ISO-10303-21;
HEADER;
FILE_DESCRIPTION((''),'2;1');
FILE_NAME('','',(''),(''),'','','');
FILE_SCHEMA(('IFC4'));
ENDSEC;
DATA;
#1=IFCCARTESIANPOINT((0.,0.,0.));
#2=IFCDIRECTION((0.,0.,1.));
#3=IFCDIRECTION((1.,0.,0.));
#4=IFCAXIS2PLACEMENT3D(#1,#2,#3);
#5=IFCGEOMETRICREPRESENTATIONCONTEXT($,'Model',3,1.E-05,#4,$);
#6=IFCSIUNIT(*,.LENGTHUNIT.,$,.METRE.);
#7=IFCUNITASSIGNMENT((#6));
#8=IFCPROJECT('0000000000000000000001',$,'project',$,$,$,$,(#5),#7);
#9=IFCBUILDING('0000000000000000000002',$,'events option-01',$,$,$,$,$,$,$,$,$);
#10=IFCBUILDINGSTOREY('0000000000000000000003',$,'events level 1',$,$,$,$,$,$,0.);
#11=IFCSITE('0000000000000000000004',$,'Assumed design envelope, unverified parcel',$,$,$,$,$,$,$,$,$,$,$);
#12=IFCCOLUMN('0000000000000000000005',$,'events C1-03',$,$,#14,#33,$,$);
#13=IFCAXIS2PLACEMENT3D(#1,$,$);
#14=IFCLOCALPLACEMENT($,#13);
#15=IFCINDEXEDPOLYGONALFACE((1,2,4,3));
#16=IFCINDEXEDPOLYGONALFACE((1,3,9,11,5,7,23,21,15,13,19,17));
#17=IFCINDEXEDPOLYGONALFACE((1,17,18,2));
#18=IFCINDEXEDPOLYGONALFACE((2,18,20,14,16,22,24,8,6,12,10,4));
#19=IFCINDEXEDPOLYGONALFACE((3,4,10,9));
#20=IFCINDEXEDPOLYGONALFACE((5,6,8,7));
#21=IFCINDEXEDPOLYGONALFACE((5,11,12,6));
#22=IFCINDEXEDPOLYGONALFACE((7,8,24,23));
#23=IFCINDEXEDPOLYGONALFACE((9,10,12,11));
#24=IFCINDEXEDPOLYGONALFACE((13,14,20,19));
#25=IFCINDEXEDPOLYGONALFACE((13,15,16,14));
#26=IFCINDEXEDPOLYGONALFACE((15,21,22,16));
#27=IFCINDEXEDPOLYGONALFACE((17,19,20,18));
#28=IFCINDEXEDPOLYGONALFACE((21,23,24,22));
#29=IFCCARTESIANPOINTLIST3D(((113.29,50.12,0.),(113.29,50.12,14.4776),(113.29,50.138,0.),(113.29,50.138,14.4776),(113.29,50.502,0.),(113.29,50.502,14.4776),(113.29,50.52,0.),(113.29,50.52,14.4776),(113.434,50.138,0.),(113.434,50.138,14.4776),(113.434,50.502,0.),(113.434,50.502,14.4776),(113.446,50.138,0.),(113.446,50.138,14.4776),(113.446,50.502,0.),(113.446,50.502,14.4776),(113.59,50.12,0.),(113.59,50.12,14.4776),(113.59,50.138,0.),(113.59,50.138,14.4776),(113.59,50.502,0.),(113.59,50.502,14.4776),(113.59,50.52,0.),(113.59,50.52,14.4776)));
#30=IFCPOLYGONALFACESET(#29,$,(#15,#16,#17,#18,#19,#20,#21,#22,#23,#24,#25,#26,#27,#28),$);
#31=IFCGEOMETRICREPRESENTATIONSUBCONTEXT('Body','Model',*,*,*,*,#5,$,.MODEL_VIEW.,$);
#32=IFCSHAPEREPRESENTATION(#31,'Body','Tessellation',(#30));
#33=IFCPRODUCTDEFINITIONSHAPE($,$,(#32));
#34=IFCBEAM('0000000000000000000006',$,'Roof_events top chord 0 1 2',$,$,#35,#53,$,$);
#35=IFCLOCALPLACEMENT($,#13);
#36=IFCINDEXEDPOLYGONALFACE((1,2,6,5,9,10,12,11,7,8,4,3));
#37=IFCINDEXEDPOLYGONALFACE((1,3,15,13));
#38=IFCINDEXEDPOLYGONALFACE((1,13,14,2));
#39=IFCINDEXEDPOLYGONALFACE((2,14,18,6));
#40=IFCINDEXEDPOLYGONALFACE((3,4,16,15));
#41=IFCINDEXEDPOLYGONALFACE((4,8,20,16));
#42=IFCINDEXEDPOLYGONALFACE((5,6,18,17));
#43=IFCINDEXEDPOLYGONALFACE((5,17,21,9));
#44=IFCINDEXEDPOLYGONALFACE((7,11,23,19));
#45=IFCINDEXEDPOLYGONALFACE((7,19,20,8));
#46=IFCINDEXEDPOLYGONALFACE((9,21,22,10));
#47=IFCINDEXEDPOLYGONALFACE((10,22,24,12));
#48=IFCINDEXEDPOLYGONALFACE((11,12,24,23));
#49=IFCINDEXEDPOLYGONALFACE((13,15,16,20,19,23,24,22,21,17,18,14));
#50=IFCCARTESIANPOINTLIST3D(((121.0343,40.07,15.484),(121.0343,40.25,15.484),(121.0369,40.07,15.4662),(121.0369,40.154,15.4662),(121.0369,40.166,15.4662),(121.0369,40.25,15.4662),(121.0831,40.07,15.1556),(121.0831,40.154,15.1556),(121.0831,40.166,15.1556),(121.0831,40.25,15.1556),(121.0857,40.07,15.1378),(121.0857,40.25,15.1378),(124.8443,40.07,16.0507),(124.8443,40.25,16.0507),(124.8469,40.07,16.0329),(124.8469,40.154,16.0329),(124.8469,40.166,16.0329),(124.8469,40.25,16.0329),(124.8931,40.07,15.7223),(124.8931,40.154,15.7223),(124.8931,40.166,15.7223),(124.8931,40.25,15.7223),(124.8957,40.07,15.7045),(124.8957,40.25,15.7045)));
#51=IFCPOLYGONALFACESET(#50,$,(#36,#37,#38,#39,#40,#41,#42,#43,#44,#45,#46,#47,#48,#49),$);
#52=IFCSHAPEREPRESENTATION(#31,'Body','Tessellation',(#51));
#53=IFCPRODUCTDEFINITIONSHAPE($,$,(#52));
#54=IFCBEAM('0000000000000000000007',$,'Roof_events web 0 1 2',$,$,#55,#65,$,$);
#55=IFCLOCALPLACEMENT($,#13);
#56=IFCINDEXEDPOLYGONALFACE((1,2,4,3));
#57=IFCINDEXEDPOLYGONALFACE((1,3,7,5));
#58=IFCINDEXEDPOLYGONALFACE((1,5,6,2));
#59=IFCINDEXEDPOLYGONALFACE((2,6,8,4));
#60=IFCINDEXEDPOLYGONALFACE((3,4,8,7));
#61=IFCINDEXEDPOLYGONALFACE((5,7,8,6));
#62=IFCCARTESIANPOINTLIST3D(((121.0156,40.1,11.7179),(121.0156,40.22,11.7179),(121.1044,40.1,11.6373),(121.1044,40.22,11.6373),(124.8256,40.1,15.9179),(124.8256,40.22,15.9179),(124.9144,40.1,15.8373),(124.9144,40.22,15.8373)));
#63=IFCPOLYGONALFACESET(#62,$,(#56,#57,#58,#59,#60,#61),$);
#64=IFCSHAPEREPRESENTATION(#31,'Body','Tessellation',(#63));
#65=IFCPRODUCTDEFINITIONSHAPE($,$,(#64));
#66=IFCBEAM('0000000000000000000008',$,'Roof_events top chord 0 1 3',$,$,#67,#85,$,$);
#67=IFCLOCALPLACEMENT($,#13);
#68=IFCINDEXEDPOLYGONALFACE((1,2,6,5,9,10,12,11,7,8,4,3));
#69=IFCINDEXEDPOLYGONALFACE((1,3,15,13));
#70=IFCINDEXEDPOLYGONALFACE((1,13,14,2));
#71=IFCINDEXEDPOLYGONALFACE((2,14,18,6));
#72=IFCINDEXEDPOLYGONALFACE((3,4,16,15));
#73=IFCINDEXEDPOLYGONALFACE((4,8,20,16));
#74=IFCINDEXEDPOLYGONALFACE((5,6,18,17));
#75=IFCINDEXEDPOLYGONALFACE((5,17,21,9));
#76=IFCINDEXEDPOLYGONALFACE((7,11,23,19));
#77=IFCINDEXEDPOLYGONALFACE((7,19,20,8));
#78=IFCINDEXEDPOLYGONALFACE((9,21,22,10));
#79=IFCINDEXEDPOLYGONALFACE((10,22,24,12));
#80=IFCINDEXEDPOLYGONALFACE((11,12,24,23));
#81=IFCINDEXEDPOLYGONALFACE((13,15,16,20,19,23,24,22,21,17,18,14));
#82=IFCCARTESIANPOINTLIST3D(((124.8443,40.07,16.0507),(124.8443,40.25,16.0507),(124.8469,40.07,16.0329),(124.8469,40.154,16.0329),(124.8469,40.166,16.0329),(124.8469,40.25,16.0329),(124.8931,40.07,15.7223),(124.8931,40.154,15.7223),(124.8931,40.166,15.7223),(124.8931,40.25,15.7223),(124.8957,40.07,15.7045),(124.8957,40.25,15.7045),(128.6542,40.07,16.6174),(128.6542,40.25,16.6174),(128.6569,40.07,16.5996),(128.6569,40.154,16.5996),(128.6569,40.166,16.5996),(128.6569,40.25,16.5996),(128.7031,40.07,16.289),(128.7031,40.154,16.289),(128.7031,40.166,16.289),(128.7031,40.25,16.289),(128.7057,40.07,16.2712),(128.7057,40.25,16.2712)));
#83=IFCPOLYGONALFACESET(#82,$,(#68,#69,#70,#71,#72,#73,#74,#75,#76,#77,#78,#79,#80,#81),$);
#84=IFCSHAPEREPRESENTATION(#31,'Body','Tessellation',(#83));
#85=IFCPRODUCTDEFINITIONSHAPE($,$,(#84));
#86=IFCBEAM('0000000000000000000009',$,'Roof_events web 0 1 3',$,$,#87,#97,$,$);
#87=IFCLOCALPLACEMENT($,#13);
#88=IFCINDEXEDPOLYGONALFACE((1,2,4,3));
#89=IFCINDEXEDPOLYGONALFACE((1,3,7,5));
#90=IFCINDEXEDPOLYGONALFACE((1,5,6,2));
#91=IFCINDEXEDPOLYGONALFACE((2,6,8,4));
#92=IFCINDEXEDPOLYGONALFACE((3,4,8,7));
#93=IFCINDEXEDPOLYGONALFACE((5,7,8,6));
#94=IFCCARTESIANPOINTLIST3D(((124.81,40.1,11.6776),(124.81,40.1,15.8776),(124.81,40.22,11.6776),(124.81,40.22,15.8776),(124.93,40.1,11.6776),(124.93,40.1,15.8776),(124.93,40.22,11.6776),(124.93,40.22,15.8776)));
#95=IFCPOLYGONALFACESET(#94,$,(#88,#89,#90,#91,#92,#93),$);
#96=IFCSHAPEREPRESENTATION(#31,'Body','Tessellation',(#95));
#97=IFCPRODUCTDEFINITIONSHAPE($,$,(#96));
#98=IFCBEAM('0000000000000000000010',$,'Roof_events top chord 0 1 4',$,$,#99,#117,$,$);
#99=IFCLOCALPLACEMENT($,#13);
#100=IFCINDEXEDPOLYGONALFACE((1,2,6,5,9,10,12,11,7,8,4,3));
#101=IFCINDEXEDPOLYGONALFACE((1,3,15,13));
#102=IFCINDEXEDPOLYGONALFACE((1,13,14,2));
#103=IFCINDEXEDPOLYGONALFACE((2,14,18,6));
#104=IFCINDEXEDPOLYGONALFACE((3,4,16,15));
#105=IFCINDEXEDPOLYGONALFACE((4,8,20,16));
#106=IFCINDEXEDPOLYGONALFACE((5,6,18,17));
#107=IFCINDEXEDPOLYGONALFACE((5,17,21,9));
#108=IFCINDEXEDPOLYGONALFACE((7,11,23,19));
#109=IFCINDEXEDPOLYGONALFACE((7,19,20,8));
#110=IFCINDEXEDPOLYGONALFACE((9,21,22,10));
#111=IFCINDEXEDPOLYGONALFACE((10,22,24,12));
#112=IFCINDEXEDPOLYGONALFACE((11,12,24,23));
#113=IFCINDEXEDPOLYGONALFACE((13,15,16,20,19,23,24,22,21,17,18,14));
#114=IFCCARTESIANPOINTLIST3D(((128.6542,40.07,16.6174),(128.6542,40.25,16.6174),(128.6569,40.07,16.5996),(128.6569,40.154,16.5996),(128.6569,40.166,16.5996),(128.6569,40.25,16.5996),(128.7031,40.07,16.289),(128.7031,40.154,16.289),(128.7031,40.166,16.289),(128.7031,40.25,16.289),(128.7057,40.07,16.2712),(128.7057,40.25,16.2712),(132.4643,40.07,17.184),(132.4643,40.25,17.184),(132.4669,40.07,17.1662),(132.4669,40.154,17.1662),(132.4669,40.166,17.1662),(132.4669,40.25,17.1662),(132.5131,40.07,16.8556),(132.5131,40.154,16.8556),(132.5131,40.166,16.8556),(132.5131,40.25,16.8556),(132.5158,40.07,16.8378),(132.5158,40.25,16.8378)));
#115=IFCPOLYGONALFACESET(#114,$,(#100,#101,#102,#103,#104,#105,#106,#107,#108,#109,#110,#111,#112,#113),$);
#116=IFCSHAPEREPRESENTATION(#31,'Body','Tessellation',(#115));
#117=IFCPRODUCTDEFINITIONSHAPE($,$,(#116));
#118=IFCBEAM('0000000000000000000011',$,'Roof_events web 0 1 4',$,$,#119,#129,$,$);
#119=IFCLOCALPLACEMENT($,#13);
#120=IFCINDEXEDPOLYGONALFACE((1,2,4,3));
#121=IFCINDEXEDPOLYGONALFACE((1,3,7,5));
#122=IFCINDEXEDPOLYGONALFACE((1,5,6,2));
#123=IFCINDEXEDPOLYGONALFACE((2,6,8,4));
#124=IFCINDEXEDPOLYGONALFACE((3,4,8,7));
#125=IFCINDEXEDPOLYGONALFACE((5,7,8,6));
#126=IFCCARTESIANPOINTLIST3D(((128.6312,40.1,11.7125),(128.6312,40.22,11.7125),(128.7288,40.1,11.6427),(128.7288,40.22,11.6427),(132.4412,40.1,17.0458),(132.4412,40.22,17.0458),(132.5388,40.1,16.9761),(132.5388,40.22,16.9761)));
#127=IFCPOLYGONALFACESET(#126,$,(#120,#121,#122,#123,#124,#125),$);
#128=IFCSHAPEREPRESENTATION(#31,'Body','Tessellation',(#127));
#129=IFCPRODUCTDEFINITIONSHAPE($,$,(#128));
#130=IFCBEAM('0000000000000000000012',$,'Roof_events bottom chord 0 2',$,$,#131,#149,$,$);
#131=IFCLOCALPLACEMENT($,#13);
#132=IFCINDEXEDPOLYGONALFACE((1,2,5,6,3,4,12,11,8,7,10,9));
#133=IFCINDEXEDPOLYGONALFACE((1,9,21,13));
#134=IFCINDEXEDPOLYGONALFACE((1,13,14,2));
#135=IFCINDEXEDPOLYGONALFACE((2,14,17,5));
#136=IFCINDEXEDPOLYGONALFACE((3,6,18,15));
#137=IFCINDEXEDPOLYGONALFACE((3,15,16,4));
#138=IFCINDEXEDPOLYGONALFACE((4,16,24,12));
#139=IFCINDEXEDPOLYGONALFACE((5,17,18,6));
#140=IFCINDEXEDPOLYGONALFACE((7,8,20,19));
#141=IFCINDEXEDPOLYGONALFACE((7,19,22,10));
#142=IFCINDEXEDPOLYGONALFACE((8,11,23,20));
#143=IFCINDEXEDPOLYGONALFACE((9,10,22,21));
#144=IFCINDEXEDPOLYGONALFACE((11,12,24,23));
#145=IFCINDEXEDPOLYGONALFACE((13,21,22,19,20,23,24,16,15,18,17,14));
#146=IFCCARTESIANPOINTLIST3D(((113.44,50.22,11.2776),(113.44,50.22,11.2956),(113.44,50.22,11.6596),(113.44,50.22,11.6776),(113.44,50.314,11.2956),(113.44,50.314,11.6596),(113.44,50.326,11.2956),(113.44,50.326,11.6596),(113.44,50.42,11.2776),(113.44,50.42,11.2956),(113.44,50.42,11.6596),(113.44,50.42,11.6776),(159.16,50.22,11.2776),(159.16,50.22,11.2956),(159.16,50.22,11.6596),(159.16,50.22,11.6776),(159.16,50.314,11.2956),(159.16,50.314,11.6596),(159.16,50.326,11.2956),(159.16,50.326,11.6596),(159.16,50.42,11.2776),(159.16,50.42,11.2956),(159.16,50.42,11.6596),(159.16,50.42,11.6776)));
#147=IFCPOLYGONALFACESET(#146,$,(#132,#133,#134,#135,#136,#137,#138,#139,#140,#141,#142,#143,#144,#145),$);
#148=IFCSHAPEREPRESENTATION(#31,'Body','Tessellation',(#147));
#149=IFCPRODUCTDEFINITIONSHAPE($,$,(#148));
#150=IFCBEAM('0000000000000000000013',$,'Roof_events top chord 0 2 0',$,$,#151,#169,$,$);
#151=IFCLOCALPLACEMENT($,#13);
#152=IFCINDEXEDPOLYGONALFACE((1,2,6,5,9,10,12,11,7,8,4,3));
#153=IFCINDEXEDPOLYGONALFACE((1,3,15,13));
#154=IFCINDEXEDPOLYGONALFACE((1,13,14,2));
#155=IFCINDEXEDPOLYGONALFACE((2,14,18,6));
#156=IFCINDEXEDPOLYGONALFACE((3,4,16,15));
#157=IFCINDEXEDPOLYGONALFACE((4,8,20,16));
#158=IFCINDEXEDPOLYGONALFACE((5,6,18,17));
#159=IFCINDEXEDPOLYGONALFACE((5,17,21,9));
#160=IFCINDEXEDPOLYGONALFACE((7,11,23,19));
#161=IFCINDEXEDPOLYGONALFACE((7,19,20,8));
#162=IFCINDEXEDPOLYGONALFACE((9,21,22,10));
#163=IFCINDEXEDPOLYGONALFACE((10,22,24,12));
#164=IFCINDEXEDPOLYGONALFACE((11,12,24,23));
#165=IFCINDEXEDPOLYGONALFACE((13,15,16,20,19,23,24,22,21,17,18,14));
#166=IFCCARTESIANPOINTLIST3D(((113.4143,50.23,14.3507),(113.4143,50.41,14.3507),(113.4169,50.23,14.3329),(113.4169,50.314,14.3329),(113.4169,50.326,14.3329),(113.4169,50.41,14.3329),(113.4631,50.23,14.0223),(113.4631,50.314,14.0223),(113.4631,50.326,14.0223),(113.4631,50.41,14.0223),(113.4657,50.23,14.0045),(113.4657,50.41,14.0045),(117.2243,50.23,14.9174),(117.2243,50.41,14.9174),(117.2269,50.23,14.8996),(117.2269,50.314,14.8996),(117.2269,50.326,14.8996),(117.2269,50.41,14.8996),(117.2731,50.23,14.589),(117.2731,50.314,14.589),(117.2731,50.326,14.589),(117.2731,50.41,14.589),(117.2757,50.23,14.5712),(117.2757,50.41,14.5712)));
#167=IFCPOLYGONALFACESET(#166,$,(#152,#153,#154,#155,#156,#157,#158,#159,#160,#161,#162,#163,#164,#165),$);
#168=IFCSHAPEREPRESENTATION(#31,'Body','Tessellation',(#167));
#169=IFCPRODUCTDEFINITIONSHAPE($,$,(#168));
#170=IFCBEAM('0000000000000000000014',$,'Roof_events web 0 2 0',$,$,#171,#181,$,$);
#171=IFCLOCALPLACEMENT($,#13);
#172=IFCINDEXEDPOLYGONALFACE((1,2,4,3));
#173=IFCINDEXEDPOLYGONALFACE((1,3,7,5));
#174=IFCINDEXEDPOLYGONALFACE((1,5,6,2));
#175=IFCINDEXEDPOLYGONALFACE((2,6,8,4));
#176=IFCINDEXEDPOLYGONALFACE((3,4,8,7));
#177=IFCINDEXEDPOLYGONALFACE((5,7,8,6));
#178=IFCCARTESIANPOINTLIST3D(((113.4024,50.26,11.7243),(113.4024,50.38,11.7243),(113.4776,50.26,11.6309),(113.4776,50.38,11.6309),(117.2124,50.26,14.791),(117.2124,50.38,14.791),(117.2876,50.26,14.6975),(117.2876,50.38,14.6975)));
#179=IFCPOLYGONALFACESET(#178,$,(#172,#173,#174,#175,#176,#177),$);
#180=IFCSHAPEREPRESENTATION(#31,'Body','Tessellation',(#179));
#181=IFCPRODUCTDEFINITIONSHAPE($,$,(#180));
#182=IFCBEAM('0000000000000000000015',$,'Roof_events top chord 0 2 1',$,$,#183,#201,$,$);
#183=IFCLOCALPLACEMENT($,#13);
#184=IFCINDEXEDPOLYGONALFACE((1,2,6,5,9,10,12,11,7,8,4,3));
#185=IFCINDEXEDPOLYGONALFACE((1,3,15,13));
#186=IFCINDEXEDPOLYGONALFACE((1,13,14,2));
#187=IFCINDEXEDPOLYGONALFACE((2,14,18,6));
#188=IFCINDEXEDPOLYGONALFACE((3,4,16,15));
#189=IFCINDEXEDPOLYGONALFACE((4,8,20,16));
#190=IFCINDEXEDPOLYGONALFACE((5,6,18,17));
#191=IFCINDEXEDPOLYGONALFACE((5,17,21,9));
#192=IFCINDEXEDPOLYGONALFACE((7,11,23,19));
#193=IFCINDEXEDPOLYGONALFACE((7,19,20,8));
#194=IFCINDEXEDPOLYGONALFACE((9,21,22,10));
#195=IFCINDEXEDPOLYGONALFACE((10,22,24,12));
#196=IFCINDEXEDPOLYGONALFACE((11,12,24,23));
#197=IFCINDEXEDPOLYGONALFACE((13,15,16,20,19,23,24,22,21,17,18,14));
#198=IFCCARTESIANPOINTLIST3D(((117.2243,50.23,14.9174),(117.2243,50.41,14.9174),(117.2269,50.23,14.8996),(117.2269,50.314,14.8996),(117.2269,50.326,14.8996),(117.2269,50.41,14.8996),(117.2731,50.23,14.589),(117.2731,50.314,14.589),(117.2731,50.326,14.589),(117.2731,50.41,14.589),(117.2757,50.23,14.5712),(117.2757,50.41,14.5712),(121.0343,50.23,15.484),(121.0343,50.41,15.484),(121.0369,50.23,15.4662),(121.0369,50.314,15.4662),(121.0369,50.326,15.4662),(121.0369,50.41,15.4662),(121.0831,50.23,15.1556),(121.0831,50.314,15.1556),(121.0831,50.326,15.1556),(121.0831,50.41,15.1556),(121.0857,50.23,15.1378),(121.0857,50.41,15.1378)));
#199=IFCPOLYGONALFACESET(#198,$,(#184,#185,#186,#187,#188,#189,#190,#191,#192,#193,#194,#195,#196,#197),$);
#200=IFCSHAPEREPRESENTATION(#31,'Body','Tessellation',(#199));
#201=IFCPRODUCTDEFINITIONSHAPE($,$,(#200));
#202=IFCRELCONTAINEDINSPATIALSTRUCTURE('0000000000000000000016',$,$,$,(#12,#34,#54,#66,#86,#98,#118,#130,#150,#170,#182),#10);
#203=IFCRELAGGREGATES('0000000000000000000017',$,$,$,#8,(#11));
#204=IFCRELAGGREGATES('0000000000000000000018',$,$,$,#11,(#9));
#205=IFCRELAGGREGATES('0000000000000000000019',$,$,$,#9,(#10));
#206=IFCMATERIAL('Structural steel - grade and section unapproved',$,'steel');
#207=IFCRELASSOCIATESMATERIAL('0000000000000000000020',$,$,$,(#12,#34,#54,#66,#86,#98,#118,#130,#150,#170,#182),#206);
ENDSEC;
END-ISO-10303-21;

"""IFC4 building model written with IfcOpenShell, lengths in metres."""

from ifc_helpers import new_model, si_unit, frame, origin_with_axes, place, context, subcontext, project, spatial, rectangle, i_section, extrude, material, element, save


model = new_model("IFC4")

# Units and contexts
model_context = context("Model", 3, precision=1e-05, world=origin_with_axes())
body_context = subcontext(model_context, "Body", "Model", "MODEL_VIEW")
ifc_project = project(units=[si_unit("LENGTHUNIT", "METRE")], contexts=[model_context])

# Site, building, storey
site = spatial("IfcSite", under=ifc_project, Name="Assumed design envelope, unverified parcel")
building = spatial("IfcBuilding", under=site, Name="events option-01")
storey = spatial("IfcBuildingStorey", under=building, Name="events level 1", Elevation=0.0)

# Column
ifc_material_1 = material(Name="Structural steel - grade and section unapproved", Category="steel")
column_placement = place(None, frame((113.44, 50.32, 0.0), z_axis=(0.0, 0.0, 1.0), x_axis=(-1.0, 0.0, 0.0)))
element("IfcColumn", 1, at=column_placement, inside=storey, material=ifc_material_1, Name="events C1-03", context=body_context, shape_type="SweptSolid", body=[
    extrude(i_section(OverallWidth=0.3, OverallDepth=0.4, WebThickness=0.012, FlangeThickness=0.018, FilletRadius=0.0), origin_with_axes(), (0.0, 0.0, 1.0), 14.4776),
])

# Beams
beam_1_placement = place(None, frame((121.06, 40.16, 15.3109), z_axis=(0.98912, 0.0, 0.147113), x_axis=(0.0, 1.0, 0.0)))
element("IfcBeam", 2, at=beam_1_placement, inside=storey, material=ifc_material_1, Name="Roof_events top chord 0 1 2", context=body_context, shape_type="SweptSolid", body=[
    extrude(i_section(OverallWidth=0.18, OverallDepth=0.35, WebThickness=0.012, FlangeThickness=0.018, FilletRadius=0.0), origin_with_axes(), (0.0, 0.0, 1.0), 3.8519),
])
beam_2_placement = place(None, frame((121.06, 40.16, 11.6776), z_axis=(0.671883, 0.0, 0.740657), x_axis=(0.0, 1.0, 0.0)))
element("IfcBeam", 3, at=beam_2_placement, inside=storey, material=ifc_material_1, Name="Roof_events web 0 1 2", context=body_context, shape_type="SweptSolid", body=[
    extrude(rectangle(XDim=0.12, YDim=0.12), origin_with_axes(), (0.0, 0.0, 1.0), 5.6706),
])
beam_3_placement = place(None, frame((124.87, 40.16, 15.8776), z_axis=(0.98912, 0.0, 0.147114), x_axis=(0.0, 1.0, 0.0)))
element("IfcBeam", 4, at=beam_3_placement, inside=storey, material=ifc_material_1, Name="Roof_events top chord 0 1 3", context=body_context, shape_type="SweptSolid", body=[
    extrude(i_section(OverallWidth=0.18, OverallDepth=0.35, WebThickness=0.012, FlangeThickness=0.018, FilletRadius=0.0), origin_with_axes(), (0.0, 0.0, 1.0), 3.8519),
])
beam_4_placement = place(None, frame((124.87, 40.16, 11.6776), z_axis=(0.0, 0.0, 1.0), x_axis=(-1.0, 0.0, 0.0)))
element("IfcBeam", 5, at=beam_4_placement, inside=storey, material=ifc_material_1, Name="Roof_events web 0 1 3", context=body_context, shape_type="SweptSolid", body=[
    extrude(rectangle(XDim=0.12, YDim=0.12), origin_with_axes(), (0.0, 0.0, 1.0), 4.2),
])
beam_5_placement = place(None, frame((128.68, 40.16, 16.4443), z_axis=(0.98912, 0.0, 0.147112), x_axis=(0.0, 1.0, 0.0)))
element("IfcBeam", 6, at=beam_5_placement, inside=storey, material=ifc_material_1, Name="Roof_events top chord 0 1 4", context=body_context, shape_type="SweptSolid", body=[
    extrude(i_section(OverallWidth=0.18, OverallDepth=0.35, WebThickness=0.012, FlangeThickness=0.018, FilletRadius=0.0), origin_with_axes(), (0.0, 0.0, 1.0), 3.8519),
])
beam_6_placement = place(None, frame((128.68, 40.16, 11.6776), z_axis=(0.581288, 0.0, 0.813698), x_axis=(0.0, 1.0, 0.0)))
element("IfcBeam", 7, at=beam_6_placement, inside=storey, material=ifc_material_1, Name="Roof_events web 0 1 4", context=body_context, shape_type="SweptSolid", body=[
    extrude(rectangle(XDim=0.12, YDim=0.12), origin_with_axes(), (0.0, 0.0, 1.0), 6.5544),
])
beam_7_placement = place(None, frame((113.44, 50.32, 11.4776), z_axis=(1.0, 0.0, 0.0), x_axis=(0.0, 1.0, 0.0)))
element("IfcBeam", 8, at=beam_7_placement, inside=storey, material=ifc_material_1, Name="Roof_events bottom chord 0 2", context=body_context, shape_type="SweptSolid", body=[
    extrude(i_section(OverallWidth=0.2, OverallDepth=0.4, WebThickness=0.012, FlangeThickness=0.018, FilletRadius=0.0), origin_with_axes(), (0.0, 0.0, 1.0), 45.72),
])
beam_8_placement = place(None, frame((113.44, 50.32, 14.1776), z_axis=(0.98912, 0.0, 0.147113), x_axis=(0.0, 1.0, 0.0)))
element("IfcBeam", 9, at=beam_8_placement, inside=storey, material=ifc_material_1, Name="Roof_events top chord 0 2 0", context=body_context, shape_type="SweptSolid", body=[
    extrude(i_section(OverallWidth=0.18, OverallDepth=0.35, WebThickness=0.012, FlangeThickness=0.018, FilletRadius=0.0), origin_with_axes(), (0.0, 0.0, 1.0), 3.8519),
])
beam_9_placement = place(None, frame((113.44, 50.32, 11.6776), z_axis=(0.779003, 0.0, 0.62702), x_axis=(0.0, 1.0, 0.0)))
element("IfcBeam", 10, at=beam_9_placement, inside=storey, material=ifc_material_1, Name="Roof_events web 0 2 0", context=body_context, shape_type="SweptSolid", body=[
    extrude(rectangle(XDim=0.12, YDim=0.12), origin_with_axes(), (0.0, 0.0, 1.0), 4.8909),
])
beam_10_placement = place(None, frame((117.25, 50.32, 14.7443), z_axis=(0.98912, 0.0, 0.147113), x_axis=(0.0, 1.0, 0.0)))
element("IfcBeam", 11, at=beam_10_placement, inside=storey, material=ifc_material_1, Name="Roof_events top chord 0 2 1", context=body_context, shape_type="SweptSolid", body=[
    extrude(i_section(OverallWidth=0.18, OverallDepth=0.35, WebThickness=0.012, FlangeThickness=0.018, FilletRadius=0.0), origin_with_axes(), (0.0, 0.0, 1.0), 3.8519),
])

save(model, "model.ifc")
